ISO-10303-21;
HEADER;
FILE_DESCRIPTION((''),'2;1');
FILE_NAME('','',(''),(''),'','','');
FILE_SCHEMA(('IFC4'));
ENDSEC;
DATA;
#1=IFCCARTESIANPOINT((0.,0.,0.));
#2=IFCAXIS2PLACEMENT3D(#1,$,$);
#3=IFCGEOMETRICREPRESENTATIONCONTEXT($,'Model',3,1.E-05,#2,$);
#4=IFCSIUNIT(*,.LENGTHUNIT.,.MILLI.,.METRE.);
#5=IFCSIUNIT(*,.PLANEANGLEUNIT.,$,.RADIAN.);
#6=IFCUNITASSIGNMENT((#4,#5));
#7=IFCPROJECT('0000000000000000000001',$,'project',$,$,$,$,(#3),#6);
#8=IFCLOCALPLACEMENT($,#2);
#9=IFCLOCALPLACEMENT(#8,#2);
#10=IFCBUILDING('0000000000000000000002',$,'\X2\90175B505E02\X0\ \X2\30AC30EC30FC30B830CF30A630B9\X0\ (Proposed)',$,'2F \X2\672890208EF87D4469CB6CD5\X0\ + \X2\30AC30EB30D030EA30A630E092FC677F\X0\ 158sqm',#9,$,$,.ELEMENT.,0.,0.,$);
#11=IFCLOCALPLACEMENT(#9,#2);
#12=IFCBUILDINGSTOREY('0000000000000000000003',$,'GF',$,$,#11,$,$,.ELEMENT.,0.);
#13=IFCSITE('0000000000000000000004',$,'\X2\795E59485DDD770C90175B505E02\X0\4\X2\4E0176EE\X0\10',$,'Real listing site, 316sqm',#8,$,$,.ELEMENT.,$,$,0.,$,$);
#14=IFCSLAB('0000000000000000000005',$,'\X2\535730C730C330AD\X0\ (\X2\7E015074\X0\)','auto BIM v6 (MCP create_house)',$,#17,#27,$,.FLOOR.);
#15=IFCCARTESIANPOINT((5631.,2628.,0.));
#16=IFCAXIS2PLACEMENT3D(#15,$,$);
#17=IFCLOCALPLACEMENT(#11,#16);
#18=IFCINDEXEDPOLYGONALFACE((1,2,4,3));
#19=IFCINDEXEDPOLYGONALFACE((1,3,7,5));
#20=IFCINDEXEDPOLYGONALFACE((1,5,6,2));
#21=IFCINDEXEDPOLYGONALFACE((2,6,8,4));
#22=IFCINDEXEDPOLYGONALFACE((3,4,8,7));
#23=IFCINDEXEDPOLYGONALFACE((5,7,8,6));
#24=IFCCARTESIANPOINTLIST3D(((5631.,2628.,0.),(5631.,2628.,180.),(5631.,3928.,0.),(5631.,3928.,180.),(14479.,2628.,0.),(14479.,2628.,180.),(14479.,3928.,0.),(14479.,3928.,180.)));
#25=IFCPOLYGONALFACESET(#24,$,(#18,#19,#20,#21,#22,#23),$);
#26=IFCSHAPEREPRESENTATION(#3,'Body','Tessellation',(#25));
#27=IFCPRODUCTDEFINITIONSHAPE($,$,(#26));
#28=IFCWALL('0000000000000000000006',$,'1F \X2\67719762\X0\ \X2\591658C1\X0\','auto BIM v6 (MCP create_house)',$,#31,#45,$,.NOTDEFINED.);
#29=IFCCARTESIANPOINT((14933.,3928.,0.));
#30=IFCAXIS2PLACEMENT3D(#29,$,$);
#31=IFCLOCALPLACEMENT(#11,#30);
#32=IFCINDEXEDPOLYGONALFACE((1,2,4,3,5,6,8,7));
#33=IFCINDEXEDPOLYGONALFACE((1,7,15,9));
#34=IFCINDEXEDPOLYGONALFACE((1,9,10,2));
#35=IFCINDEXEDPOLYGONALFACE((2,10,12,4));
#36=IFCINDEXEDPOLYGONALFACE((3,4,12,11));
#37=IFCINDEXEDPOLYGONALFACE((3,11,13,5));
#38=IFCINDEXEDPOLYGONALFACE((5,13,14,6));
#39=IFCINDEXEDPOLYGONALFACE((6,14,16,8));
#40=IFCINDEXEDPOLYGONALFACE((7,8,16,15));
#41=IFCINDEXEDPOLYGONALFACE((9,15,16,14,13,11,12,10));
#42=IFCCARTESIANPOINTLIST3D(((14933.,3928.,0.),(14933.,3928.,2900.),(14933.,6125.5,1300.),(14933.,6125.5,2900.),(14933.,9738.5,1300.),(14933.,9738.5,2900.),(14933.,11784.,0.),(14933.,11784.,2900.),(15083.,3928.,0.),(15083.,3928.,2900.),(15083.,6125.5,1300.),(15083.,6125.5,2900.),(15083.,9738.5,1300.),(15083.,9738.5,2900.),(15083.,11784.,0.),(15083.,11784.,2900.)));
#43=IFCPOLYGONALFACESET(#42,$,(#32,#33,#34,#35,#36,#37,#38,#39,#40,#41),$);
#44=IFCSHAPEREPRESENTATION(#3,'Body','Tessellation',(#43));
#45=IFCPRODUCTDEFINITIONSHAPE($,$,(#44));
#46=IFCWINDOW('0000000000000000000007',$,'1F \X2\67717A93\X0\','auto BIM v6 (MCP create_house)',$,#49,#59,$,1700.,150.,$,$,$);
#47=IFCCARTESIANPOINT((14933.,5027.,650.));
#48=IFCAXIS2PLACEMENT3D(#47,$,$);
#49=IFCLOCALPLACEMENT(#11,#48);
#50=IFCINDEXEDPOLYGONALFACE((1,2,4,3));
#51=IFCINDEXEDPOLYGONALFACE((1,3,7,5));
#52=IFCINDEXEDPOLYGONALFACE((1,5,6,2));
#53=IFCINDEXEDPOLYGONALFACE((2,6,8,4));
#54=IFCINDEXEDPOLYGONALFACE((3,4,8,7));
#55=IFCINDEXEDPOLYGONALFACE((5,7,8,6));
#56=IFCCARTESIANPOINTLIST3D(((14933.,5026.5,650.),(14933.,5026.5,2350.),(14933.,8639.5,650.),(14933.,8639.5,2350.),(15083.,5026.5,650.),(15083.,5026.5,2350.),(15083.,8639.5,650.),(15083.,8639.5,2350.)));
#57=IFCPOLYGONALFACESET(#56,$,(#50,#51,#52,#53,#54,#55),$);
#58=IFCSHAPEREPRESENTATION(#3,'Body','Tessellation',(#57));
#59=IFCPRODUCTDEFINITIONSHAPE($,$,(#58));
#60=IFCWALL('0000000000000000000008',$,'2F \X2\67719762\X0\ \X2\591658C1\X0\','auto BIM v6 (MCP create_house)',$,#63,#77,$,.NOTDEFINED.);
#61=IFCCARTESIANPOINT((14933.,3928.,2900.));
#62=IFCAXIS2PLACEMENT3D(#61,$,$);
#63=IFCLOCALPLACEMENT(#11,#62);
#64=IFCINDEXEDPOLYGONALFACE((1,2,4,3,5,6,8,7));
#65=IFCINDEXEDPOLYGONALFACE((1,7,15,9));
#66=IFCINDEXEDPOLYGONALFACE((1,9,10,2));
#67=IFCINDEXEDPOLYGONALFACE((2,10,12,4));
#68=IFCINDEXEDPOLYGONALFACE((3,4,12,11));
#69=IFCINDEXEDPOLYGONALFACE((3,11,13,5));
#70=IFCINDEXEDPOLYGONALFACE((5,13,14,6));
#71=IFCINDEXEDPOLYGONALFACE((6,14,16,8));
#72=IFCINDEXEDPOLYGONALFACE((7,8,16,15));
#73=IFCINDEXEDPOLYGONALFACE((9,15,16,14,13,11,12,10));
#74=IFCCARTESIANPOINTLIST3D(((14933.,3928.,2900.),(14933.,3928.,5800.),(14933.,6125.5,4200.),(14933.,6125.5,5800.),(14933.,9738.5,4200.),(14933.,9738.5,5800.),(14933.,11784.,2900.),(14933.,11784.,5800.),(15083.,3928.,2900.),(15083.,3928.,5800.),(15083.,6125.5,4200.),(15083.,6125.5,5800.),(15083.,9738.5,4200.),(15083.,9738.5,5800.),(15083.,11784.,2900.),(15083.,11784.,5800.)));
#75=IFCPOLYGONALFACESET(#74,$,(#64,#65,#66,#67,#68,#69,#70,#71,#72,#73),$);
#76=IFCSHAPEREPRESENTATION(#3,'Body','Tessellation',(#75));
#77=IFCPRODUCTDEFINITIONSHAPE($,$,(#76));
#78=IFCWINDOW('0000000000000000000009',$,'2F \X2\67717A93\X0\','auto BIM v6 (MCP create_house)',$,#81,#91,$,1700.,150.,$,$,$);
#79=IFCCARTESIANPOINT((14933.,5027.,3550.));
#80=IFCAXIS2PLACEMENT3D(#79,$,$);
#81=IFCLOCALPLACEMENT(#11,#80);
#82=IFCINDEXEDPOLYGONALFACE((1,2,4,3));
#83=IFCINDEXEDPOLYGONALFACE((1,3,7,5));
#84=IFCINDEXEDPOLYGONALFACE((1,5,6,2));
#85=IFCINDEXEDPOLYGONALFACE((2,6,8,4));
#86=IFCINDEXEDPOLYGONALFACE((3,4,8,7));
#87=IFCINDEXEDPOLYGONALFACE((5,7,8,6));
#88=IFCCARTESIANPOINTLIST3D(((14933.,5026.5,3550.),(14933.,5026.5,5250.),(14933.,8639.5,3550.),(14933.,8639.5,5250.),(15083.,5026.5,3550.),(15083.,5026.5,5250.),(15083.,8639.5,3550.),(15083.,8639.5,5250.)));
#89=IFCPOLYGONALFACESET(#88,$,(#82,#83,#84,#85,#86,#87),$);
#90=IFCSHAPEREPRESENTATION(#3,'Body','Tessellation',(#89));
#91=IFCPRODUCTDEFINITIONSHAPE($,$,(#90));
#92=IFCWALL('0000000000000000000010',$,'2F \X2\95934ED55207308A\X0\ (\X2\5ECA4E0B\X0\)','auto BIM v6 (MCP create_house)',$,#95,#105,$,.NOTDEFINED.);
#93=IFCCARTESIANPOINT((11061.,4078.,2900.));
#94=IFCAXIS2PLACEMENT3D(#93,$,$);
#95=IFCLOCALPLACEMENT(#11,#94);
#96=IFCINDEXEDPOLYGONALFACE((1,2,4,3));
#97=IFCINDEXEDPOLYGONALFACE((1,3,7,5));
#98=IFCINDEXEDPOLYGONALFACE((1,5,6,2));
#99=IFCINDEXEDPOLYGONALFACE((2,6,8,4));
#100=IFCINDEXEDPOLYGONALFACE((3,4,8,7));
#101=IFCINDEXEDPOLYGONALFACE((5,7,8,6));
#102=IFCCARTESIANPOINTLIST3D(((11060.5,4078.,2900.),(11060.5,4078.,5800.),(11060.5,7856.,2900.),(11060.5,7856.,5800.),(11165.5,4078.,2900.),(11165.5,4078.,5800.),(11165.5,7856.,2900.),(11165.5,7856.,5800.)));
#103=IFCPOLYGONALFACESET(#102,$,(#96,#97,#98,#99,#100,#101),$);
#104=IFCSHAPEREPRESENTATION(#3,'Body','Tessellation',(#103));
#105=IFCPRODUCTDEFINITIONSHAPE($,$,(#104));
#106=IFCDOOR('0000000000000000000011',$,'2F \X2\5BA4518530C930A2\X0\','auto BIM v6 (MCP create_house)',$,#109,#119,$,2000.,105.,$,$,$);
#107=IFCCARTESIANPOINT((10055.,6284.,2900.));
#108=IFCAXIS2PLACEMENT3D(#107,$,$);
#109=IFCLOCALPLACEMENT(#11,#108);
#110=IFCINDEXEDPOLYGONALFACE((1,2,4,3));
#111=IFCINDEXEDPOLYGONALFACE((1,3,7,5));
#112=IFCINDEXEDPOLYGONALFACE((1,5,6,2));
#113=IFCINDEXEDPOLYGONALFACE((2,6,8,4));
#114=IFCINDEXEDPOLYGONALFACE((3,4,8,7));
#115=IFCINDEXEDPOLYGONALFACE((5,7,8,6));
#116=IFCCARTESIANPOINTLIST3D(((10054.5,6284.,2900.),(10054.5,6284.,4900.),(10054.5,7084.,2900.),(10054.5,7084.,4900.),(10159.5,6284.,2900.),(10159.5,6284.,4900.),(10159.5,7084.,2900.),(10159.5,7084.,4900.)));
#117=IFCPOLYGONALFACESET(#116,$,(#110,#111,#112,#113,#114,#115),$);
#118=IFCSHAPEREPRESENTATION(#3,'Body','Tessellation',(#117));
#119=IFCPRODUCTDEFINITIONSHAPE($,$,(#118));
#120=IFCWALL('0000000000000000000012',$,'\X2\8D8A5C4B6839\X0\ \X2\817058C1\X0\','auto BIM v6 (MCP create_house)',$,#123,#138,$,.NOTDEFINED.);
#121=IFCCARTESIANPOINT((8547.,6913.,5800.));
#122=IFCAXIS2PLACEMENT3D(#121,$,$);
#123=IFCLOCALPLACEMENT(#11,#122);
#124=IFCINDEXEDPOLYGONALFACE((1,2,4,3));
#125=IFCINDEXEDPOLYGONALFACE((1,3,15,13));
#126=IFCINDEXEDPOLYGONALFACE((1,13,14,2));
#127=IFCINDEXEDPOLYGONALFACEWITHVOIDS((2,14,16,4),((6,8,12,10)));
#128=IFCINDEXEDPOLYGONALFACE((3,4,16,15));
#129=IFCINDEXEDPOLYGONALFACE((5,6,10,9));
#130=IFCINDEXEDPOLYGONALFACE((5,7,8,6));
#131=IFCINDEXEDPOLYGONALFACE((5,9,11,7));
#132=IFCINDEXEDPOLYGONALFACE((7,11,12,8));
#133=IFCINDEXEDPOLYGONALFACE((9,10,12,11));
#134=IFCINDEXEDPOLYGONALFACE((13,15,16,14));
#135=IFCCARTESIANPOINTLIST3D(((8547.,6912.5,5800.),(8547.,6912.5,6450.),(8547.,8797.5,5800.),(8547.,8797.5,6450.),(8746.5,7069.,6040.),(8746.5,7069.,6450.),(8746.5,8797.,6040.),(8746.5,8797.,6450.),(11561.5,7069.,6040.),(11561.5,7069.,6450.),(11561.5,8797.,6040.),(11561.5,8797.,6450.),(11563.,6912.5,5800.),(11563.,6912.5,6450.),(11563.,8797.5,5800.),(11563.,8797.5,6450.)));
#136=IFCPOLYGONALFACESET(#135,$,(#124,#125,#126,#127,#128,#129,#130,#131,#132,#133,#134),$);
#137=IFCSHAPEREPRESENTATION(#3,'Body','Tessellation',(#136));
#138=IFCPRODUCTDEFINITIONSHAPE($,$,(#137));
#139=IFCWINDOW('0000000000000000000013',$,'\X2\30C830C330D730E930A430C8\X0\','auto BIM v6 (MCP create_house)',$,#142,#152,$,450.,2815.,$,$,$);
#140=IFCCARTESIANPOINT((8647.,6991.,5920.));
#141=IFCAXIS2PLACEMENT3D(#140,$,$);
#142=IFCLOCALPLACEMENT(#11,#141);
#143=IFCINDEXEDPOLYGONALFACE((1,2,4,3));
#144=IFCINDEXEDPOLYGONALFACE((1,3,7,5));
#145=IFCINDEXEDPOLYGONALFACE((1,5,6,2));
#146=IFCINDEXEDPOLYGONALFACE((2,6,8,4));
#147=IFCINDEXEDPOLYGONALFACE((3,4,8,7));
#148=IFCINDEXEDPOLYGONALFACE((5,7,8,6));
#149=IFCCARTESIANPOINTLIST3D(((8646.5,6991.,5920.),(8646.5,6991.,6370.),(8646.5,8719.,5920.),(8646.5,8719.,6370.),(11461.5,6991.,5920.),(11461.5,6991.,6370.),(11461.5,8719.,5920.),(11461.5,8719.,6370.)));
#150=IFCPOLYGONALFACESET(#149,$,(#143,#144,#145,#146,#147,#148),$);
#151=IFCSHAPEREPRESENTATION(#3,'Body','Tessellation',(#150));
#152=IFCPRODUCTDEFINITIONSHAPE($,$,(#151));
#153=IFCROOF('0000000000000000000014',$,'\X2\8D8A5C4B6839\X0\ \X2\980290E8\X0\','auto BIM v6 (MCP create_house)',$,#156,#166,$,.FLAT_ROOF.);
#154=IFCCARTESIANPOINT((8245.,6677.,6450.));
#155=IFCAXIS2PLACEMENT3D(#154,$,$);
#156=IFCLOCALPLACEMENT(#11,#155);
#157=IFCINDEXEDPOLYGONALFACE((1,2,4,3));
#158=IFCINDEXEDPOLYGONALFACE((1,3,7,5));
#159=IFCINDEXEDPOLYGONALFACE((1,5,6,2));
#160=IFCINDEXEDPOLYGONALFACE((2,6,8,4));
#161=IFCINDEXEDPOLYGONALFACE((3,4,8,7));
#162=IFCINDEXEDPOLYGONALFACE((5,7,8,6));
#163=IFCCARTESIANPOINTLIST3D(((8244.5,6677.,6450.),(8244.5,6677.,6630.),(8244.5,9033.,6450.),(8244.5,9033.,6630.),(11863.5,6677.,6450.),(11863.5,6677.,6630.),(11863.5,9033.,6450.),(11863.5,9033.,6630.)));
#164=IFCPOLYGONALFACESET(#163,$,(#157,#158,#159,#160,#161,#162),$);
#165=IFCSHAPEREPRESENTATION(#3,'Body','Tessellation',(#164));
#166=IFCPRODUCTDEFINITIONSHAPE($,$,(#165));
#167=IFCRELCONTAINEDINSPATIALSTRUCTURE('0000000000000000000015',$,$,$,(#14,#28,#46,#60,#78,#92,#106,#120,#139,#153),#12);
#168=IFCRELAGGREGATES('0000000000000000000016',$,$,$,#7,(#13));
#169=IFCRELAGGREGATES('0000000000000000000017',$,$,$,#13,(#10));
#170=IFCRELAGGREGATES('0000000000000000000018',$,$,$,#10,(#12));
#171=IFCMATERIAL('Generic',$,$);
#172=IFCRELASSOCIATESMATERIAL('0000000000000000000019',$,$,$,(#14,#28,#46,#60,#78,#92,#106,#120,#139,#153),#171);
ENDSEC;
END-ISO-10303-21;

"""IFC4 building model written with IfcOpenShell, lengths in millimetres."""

from ifc_helpers import new_model, si_unit, frame, frame_2d, origin, place, context, project, spatial, rectangle, extrude, material, element, fill, save


model = new_model("IFC4")

# Units and contexts
model_context = context("Model", 3, precision=1e-05, world=origin())
ifc_project = project(units=[si_unit("LENGTHUNIT", "METRE", prefix="MILLI"), si_unit("PLANEANGLEUNIT", "RADIAN")], contexts=[model_context])

# Site, building, storey
site_placement = place(None, origin())
site = spatial("IfcSite", under=ifc_project, at=site_placement, Name="神奈川県逗子市4丁目10", ObjectType="Real listing site, 316sqm", CompositionType="ELEMENT", RefElevation=0.0)
building_placement = place(site_placement, origin())
building = spatial("IfcBuilding", under=site, at=building_placement, Name="逗子市 ガレージハウス (Proposed)", ObjectType="2F 木造軸組構法 + ガルバリウム鋼板 158sqm", CompositionType="ELEMENT", ElevationOfRefHeight=0.0, ElevationOfTerrain=0.0)
storey_placement = place(building_placement, origin())
storey = spatial("IfcBuildingStorey", under=building, at=storey_placement, Name="GF", CompositionType="ELEMENT", Elevation=0.0)

# Slab
ifc_material = material(Name="Generic")
slab_placement = place(storey_placement, frame((5631.0, 2628.0, 0.0)))
element("IfcSlab", 1, at=slab_placement, inside=storey, material=ifc_material, Name="南デッキ (縁側)", Description="auto BIM v6 (MCP create_house)", PredefinedType="FLOOR", context=model_context, shape_type="SweptSolid", body=[
    extrude(rectangle(XDim=8848.0, YDim=1300.0, at=frame_2d((4424.0, 650.0))), frame((5631.0, 2628.0, 0.0)), (0.0, 0.0, 1.0), 180.0),
])

# Wall, opening, window
wall_1_placement = place(storey_placement, frame((14933.0, 3928.0, 0.0)))
wall_1 = element("IfcWall", 2, at=wall_1_placement, inside=storey, material=ifc_material, Name="1F 東面 外壁", Description="auto BIM v6 (MCP create_house)", PredefinedType="NOTDEFINED", context=model_context, shape_type="SweptSolid", body=[
    extrude(rectangle(XDim=150.0, YDim=7856.0, at=frame_2d((75.0, 3928.0))), frame((14933.0, 3928.0, 0.0)), (0.0, 0.0, 1.0), 2900.0),
])
opening_1_placement = place(storey_placement, frame((14933.0, 5027.0, 650.0)))
opening_1 = element("IfcOpeningElement", 3, at=opening_1_placement, cuts=wall_1, PredefinedType="NOTDEFINED", context=model_context, shape_type="SweptSolid", body=[
    extrude(rectangle(XDim=150.0, YDim=3613.0, at=frame_2d((75.0, 1806.0))), frame((14933.0, 5027.0, 650.0)), (0.0, 0.0, 1.0), 1700.0),
])
window_1_placement = place(storey_placement, frame((14933.0, 5027.0, 650.0)))
window_1 = element("IfcWindow", 4, at=window_1_placement, inside=storey, material=ifc_material, Name="1F 東窓", Description="auto BIM v6 (MCP create_house)", OverallHeight=1700.0, OverallWidth=150.0, context=model_context, shape_type="SweptSolid", body=[
    extrude(rectangle(XDim=150.0, YDim=3613.0, at=frame_2d((75.0, 1806.0))), frame((14933.0, 5027.0, 650.0)), (0.0, 0.0, 1.0), 1700.0),
])
fill(opening_1, window_1)

# Wall, opening, window
wall_2_placement = place(storey_placement, frame((14933.0, 3928.0, 2900.0)))
wall_2 = element("IfcWall", 5, at=wall_2_placement, inside=storey, material=ifc_material, Name="2F 東面 外壁", Description="auto BIM v6 (MCP create_house)", PredefinedType="NOTDEFINED", context=model_context, shape_type="SweptSolid", body=[
    extrude(rectangle(XDim=150.0, YDim=7856.0, at=frame_2d((75.0, 3928.0))), frame((14933.0, 3928.0, 2900.0)), (0.0, 0.0, 1.0), 2900.0),
])
opening_2_placement = place(storey_placement, frame((14933.0, 5027.0, 3550.0)))
opening_2 = element("IfcOpeningElement", 6, at=opening_2_placement, cuts=wall_2, PredefinedType="NOTDEFINED", context=model_context, shape_type="SweptSolid", body=[
    extrude(rectangle(XDim=150.0, YDim=3613.0, at=frame_2d((75.0, 1806.0))), frame((14933.0, 5027.0, 3550.0)), (0.0, 0.0, 1.0), 1700.0),
])
window_2_placement = place(storey_placement, frame((14933.0, 5027.0, 3550.0)))
window_2 = element("IfcWindow", 7, at=window_2_placement, inside=storey, material=ifc_material, Name="2F 東窓", Description="auto BIM v6 (MCP create_house)", OverallHeight=1700.0, OverallWidth=150.0, context=model_context, shape_type="SweptSolid", body=[
    extrude(rectangle(XDim=150.0, YDim=3613.0, at=frame_2d((75.0, 1806.0))), frame((14933.0, 5027.0, 3550.0)), (0.0, 0.0, 1.0), 1700.0),
])
fill(opening_2, window_2)

# Wall
wall_3_placement = place(storey_placement, frame((11061.0, 4078.0, 2900.0)))
element("IfcWall", 8, at=wall_3_placement, inside=storey, material=ifc_material, Name="2F 間仕切り (廊下)", Description="auto BIM v6 (MCP create_house)", PredefinedType="NOTDEFINED", context=model_context, shape_type="SweptSolid", body=[
    extrude(rectangle(XDim=105.0, YDim=3778.0, at=frame_2d((52.0, 1889.0))), frame((11061.0, 4078.0, 2900.0)), (0.0, 0.0, 1.0), 2900.0),
])

# Door
door_placement = place(storey_placement, frame((10055.0, 6284.0, 2900.0)))
element("IfcDoor", 9, at=door_placement, inside=storey, material=ifc_material, Name="2F 室内ドア", Description="auto BIM v6 (MCP create_house)", OverallHeight=2000.0, OverallWidth=105.0, context=model_context, shape_type="SweptSolid", body=[
    extrude(rectangle(XDim=105.0, YDim=800.0, at=frame_2d((52.0, 400.0))), frame((10055.0, 6284.0, 2900.0)), (0.0, 0.0, 1.0), 2000.0),
])

# Wall, opening, window
wall_4_placement = place(storey_placement, frame((8547.0, 6913.0, 5800.0)))
wall_4 = element("IfcWall", 10, at=wall_4_placement, inside=storey, material=ifc_material, Name="越屋根 腰壁", Description="auto BIM v6 (MCP create_house)", PredefinedType="NOTDEFINED", context=model_context, shape_type="SweptSolid", body=[
    extrude(rectangle(XDim=3016.0, YDim=1885.0, at=frame_2d((1508.0, 942.0))), frame((8547.0, 6913.0, 5800.0)), (0.0, 0.0, 1.0), 650.0),
])
opening_3_placement = place(storey_placement, frame((8647.0, 6991.0, 5920.0)))
opening_3 = element("IfcOpeningElement", 11, at=opening_3_placement, cuts=wall_4, PredefinedType="NOTDEFINED", context=model_context, shape_type="SweptSolid", body=[
    extrude(rectangle(XDim=2815.0, YDim=1728.0, at=frame_2d((1407.0, 864.0))), frame((8647.0, 6991.0, 5920.0)), (0.0, 0.0, 1.0), 450.0),
])
window_3_placement = place(storey_placement, frame((8647.0, 6991.0, 5920.0)))
window_3 = element("IfcWindow", 12, at=window_3_placement, inside=storey, material=ifc_material, Name="トップライト", Description="auto BIM v6 (MCP create_house)", OverallHeight=450.0, OverallWidth=2815.0, context=model_context, shape_type="SweptSolid", body=[
    extrude(rectangle(XDim=2815.0, YDim=1728.0, at=frame_2d((1407.0, 864.0))), frame((8647.0, 6991.0, 5920.0)), (0.0, 0.0, 1.0), 450.0),
])
fill(opening_3, window_3)

# Roof
roof_placement = place(storey_placement, frame((8245.0, 6677.0, 6450.0)))
element("IfcRoof", 13, at=roof_placement, inside=storey, material=ifc_material, Name="越屋根 頂部", Description="auto BIM v6 (MCP create_house)", PredefinedType="FLAT_ROOF", context=model_context, shape_type="SweptSolid", body=[
    extrude(rectangle(XDim=3619.0, YDim=2356.0, at=frame_2d((1809.0, 1178.0))), frame((8245.0, 6677.0, 6450.0)), (0.0, 0.0, 1.0), 180.0),
])

save(model, "model.ifc")
